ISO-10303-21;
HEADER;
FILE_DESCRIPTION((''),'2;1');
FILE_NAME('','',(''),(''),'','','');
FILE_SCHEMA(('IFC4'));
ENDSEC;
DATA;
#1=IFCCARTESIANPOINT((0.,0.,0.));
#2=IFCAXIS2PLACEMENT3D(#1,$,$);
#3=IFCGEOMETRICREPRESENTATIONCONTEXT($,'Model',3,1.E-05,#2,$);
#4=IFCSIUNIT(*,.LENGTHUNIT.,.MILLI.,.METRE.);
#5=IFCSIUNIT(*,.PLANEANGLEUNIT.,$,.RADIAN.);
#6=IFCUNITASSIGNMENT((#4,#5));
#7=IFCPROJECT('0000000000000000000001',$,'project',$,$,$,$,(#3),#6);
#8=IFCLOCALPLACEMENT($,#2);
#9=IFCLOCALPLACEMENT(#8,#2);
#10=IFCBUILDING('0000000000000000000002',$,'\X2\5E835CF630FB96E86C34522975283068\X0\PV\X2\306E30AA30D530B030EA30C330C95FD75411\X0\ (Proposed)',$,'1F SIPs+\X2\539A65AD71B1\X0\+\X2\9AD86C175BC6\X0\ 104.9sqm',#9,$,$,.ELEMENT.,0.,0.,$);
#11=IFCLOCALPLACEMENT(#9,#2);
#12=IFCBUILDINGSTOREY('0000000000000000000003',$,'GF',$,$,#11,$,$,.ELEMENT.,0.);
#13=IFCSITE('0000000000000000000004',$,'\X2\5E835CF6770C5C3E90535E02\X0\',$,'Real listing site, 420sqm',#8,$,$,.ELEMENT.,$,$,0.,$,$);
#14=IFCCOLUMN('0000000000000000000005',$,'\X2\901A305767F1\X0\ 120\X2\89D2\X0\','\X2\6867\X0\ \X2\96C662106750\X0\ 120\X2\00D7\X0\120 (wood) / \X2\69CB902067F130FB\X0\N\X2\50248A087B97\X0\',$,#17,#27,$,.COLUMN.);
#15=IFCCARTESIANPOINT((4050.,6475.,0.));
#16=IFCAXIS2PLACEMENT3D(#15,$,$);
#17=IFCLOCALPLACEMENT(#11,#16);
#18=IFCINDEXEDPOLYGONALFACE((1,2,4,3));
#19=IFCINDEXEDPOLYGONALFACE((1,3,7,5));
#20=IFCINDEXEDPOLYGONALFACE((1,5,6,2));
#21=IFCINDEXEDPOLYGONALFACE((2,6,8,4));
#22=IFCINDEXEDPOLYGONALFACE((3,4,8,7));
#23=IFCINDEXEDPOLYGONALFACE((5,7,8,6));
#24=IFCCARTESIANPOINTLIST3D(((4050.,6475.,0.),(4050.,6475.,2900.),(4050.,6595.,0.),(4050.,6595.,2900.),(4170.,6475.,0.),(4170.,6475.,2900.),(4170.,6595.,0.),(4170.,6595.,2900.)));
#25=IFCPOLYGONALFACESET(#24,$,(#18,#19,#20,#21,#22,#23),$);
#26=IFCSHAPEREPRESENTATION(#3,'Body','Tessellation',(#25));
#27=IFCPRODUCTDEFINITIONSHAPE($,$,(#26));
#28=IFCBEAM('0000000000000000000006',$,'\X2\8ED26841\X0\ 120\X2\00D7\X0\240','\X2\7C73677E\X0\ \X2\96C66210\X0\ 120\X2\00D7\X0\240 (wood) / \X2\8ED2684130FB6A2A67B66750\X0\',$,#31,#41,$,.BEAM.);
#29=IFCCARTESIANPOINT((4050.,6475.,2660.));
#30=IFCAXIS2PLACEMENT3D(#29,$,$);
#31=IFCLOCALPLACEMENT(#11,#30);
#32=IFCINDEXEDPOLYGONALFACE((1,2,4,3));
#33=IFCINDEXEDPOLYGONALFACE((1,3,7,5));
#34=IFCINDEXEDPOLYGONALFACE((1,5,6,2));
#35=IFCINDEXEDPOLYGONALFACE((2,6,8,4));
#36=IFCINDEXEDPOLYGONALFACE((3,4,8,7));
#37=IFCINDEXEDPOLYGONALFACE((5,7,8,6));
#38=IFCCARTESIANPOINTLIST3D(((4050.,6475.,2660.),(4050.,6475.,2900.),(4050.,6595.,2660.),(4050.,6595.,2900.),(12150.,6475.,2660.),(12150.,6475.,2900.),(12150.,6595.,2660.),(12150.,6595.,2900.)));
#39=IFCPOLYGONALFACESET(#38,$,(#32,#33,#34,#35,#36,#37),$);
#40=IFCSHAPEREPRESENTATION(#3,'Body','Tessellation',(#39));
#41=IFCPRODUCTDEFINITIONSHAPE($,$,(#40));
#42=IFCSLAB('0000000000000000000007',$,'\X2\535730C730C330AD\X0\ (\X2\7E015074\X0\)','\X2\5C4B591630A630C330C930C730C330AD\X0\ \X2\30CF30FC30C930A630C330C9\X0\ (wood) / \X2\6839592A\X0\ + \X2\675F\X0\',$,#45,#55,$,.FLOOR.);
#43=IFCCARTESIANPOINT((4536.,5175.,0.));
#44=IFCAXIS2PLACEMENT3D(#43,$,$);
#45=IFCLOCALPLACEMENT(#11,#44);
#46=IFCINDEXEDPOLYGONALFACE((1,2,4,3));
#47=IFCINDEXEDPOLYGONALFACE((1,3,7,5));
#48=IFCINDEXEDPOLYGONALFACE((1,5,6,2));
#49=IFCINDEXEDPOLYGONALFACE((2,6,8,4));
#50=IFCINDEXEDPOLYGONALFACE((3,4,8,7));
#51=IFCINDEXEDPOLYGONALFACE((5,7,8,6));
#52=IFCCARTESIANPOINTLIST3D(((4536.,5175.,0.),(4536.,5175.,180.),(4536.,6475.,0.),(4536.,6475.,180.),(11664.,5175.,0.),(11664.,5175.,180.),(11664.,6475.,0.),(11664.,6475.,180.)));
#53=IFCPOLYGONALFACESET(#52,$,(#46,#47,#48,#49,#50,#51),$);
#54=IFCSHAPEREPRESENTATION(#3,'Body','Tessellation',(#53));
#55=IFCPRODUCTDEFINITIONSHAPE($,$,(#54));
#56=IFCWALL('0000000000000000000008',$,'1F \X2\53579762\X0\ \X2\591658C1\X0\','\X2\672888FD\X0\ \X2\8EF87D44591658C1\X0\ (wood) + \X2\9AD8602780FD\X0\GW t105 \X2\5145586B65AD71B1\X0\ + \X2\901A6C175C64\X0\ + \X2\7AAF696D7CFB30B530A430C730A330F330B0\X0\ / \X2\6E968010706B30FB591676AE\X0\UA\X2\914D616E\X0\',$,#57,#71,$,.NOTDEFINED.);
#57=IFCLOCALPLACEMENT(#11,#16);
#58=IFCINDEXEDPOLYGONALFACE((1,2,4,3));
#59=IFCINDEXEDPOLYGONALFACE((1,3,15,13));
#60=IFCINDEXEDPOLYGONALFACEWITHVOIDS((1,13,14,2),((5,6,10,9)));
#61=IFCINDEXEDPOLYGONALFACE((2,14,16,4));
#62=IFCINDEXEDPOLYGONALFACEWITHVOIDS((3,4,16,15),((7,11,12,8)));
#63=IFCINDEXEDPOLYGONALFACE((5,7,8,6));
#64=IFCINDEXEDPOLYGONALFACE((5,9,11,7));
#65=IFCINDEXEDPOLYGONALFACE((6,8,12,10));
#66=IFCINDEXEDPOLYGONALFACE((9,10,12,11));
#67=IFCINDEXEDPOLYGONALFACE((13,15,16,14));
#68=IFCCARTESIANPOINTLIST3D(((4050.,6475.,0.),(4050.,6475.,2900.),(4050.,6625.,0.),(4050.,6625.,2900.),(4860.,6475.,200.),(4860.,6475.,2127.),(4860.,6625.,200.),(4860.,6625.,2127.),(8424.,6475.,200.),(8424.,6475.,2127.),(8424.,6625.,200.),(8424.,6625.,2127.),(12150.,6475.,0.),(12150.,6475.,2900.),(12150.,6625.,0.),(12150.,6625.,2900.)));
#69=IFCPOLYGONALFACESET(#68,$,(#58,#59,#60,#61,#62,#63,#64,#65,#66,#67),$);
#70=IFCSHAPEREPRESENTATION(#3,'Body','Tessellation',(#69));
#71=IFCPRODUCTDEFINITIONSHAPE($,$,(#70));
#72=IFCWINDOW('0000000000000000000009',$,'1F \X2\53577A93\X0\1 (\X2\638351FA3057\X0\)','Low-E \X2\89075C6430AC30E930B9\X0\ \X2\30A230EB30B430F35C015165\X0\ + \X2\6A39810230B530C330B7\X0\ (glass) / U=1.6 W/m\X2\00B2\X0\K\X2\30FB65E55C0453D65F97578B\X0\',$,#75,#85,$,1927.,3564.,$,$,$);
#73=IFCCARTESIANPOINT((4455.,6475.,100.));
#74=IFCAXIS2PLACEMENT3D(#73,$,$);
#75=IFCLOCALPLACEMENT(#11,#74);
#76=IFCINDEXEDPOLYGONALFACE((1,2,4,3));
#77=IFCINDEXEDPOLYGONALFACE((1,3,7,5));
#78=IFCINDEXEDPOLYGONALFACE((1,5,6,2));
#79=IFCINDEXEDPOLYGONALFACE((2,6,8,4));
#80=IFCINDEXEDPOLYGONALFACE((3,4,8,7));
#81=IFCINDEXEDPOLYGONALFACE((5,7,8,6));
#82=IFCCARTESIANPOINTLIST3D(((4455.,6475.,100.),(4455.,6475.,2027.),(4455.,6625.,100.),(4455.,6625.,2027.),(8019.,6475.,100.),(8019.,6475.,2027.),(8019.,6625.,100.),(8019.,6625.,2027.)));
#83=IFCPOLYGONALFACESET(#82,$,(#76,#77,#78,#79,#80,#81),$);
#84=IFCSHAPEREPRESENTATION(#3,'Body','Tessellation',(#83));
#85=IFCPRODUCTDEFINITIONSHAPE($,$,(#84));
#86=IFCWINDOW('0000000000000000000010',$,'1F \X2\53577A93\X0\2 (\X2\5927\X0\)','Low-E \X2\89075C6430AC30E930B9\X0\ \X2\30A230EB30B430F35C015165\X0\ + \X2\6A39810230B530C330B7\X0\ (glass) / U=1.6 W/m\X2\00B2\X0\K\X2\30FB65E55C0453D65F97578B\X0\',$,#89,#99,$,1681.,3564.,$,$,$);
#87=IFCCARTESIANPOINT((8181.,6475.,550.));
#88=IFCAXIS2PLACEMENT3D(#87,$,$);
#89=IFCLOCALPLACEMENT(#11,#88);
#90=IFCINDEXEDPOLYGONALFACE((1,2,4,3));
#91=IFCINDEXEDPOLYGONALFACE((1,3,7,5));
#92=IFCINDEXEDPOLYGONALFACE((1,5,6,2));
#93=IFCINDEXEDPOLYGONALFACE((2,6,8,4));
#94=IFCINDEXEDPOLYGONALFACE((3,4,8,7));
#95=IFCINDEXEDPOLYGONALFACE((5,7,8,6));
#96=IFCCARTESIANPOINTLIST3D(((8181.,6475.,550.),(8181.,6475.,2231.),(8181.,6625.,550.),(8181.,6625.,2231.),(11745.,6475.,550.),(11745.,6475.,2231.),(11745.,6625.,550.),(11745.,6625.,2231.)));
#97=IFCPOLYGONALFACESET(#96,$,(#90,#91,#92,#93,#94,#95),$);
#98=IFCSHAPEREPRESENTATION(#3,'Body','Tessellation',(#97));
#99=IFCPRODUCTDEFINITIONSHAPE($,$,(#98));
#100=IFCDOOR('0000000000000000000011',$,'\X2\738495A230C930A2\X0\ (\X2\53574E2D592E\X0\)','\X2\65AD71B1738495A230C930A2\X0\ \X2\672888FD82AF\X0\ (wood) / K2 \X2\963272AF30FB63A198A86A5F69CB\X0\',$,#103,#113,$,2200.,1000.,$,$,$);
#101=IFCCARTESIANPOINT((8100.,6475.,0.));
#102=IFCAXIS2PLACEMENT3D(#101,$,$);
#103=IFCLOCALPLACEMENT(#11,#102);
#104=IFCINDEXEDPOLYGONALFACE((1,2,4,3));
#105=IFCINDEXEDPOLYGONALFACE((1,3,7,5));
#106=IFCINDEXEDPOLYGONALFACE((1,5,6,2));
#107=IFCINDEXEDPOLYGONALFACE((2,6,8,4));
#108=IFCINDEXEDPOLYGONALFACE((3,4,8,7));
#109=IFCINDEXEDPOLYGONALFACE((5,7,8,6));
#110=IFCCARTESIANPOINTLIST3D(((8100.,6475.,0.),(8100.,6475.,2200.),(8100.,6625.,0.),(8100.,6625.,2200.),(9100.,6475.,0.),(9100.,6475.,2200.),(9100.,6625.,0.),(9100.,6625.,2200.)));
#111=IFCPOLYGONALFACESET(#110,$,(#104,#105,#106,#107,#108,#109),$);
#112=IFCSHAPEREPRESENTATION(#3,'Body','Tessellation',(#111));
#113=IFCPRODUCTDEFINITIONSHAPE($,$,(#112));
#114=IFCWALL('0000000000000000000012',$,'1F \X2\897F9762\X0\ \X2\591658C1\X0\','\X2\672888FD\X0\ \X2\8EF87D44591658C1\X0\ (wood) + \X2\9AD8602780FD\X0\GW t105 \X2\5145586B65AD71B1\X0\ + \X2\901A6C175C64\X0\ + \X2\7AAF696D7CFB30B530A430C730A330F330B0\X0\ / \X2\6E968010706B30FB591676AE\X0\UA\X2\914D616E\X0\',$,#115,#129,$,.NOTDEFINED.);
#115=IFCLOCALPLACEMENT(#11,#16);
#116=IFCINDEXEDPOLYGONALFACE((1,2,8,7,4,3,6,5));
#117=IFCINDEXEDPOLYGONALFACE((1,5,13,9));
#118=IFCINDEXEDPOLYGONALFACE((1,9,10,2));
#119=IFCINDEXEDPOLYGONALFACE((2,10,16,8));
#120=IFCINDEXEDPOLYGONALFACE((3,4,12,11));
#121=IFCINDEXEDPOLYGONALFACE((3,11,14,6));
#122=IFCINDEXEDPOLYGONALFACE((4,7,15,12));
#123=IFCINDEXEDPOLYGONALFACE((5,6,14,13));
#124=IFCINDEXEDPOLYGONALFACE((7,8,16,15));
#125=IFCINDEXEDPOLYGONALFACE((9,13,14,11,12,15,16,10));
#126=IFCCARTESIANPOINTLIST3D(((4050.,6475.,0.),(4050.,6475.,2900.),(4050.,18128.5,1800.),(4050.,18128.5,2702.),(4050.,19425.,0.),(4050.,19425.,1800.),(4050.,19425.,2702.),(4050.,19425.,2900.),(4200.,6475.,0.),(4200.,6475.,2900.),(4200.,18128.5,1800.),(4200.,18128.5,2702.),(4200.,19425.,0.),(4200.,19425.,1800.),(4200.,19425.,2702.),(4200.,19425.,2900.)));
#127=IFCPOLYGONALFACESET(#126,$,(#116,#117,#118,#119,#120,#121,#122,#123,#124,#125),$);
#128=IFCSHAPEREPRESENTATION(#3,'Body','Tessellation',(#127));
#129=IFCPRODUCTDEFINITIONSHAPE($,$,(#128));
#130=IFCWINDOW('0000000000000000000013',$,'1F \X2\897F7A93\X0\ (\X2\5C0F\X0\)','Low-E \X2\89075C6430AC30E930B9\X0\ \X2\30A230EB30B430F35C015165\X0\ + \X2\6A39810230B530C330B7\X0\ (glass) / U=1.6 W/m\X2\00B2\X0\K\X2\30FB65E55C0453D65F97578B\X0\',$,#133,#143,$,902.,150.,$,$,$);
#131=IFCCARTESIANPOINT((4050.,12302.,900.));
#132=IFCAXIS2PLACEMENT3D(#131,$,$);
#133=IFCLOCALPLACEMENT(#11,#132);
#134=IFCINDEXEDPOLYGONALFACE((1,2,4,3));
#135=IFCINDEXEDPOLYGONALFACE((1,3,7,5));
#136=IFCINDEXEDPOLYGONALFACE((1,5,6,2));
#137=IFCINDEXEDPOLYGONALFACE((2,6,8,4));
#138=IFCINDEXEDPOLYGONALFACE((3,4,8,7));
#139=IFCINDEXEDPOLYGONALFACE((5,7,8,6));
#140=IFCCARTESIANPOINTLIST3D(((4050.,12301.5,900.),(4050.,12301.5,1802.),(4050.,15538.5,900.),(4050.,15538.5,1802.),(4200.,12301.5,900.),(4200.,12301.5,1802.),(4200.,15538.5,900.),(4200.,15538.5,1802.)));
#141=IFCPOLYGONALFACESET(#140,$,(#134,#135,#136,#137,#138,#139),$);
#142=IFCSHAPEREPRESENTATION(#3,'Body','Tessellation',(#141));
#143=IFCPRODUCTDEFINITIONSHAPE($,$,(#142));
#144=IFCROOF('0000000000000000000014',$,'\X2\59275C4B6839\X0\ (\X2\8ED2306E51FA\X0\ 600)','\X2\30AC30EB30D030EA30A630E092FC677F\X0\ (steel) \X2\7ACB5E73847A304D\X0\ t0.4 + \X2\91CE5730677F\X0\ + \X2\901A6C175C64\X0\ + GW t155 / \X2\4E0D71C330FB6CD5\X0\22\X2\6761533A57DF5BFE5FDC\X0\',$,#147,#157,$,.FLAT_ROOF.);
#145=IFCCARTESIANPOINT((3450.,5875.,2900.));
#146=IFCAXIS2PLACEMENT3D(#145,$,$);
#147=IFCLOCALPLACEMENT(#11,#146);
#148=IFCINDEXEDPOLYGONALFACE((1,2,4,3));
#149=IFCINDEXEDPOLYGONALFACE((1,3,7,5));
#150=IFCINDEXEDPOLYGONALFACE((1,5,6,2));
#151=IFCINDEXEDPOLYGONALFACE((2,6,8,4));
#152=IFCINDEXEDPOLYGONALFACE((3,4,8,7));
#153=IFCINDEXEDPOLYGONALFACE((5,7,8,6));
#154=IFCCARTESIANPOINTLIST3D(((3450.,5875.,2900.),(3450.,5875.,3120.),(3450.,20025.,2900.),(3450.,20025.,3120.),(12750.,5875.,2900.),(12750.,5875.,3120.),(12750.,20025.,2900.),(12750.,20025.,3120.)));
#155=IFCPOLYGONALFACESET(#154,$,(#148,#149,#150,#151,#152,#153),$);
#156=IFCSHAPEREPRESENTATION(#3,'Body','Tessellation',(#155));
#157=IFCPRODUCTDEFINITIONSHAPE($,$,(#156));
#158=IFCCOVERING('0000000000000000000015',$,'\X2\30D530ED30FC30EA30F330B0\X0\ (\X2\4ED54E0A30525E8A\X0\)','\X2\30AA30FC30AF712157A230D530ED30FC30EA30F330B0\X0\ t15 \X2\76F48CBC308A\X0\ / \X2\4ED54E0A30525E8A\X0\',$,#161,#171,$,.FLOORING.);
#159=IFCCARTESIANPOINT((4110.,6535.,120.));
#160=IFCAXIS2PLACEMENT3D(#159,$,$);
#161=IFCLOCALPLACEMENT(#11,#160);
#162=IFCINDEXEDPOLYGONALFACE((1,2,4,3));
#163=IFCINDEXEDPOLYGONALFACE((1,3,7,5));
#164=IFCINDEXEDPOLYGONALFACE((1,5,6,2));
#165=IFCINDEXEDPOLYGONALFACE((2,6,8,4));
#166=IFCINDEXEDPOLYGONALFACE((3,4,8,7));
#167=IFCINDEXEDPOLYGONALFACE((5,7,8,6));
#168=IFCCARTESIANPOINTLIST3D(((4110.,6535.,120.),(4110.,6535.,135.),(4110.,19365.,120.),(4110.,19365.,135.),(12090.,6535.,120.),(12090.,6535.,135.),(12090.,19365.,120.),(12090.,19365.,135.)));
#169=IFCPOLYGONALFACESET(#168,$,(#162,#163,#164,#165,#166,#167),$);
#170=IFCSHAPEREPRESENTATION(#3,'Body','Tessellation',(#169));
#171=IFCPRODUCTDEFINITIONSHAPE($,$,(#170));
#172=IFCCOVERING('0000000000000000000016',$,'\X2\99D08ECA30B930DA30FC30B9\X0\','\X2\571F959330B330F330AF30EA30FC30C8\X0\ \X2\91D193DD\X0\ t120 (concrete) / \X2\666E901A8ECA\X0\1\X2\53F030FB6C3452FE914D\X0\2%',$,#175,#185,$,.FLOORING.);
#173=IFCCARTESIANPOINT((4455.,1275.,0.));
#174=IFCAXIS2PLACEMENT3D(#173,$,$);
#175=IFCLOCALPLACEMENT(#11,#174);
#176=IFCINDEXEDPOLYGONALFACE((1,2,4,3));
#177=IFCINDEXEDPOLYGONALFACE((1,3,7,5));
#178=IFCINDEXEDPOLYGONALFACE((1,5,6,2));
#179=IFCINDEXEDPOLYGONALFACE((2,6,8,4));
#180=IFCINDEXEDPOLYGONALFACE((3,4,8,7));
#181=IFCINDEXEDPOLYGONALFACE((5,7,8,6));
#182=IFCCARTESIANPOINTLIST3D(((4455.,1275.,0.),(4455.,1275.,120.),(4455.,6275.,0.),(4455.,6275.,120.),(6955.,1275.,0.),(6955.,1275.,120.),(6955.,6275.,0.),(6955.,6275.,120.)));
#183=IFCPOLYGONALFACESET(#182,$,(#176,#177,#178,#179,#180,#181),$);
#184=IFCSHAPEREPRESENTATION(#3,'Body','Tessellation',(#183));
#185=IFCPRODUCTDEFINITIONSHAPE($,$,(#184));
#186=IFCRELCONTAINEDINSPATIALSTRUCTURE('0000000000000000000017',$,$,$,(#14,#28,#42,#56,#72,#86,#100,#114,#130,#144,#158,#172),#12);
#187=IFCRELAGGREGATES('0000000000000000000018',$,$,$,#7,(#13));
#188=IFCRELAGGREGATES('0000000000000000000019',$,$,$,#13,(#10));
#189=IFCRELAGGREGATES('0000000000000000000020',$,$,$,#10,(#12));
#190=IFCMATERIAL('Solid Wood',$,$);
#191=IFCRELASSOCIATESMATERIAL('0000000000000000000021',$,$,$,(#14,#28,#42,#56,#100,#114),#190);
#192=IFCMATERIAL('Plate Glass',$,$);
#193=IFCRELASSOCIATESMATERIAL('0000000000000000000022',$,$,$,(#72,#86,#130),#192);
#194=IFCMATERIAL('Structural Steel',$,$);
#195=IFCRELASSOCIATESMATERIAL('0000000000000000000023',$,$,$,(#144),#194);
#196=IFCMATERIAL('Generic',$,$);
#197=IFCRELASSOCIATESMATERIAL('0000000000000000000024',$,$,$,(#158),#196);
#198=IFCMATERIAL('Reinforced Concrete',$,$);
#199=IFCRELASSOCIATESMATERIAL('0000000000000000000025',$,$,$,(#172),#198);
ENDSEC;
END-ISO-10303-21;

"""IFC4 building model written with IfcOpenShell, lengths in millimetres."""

from ifc_helpers import new_model, si_unit, frame, frame_2d, origin, place, context, project, spatial, rectangle, extrude, material, element, fill, save


model = new_model("IFC4")

# Units and contexts
model_context = context("Model", 3, precision=1e-05, world=origin())
ifc_project = project(units=[si_unit("LENGTHUNIT", "METRE", prefix="MILLI"), si_unit("PLANEANGLEUNIT", "RADIAN")], contexts=[model_context])

# Site, building, storey
site_placement = place(None, origin())
site = spatial("IfcSite", under=ifc_project, at=site_placement, Name="広島県尾道市", ObjectType="Real listing site, 420sqm", CompositionType="ELEMENT", RefElevation=0.0)
building_placement = place(site_placement, origin())
building = spatial("IfcBuilding", under=site, at=building_placement, Name="広島・雨水利用とPVのオフグリッド志向 (Proposed)", ObjectType="1F SIPs+厚断熱+高気密 104.9sqm", CompositionType="ELEMENT", ElevationOfRefHeight=0.0, ElevationOfTerrain=0.0)
storey_placement = place(building_placement, origin())
storey = spatial("IfcBuildingStorey", under=building, at=storey_placement, Name="GF", CompositionType="ELEMENT", Elevation=0.0)

# Column
ifc_material_1 = material(Name="Solid Wood")
column_1_placement = place(storey_placement, frame((4050.0, 6475.0, 0.0)))
element("IfcColumn", 1, at=column_1_placement, inside=storey, material=ifc_material_1, Name="通し柱 120角", Description="桧 集成材 120×120 (wood) / 構造柱・N値計算", PredefinedType="COLUMN", context=model_context, shape_type="SweptSolid", body=[
    extrude(rectangle(XDim=120.0, YDim=120.0, at=frame_2d((60.0, 60.0))), frame((4050.0, 6475.0, 0.0)), (0.0, 0.0, 1.0), 2900.0),
])

# Beam
beam_1_placement = place(storey_placement, frame((4050.0, 6475.0, 2660.0)))
element("IfcBeam", 2, at=beam_1_placement, inside=storey, material=ifc_material_1, Name="軒桁 120×240", Description="米松 集成 120×240 (wood) / 軒桁・横架材", PredefinedType="BEAM", context=model_context, shape_type="SweptSolid", body=[
    extrude(rectangle(XDim=8100.0, YDim=120.0, at=frame_2d((4050.0, 60.0))), frame((4050.0, 6475.0, 2660.0)), (0.0, 0.0, 1.0), 240.0),
])

# Slab
ifc_material_2 = material(Name="Reinforced Concrete")
slab_1_placement = place(storey_placement, frame((4536.0, 5175.0, 0.0)))
element("IfcSlab", 3, at=slab_1_placement, inside=storey, material=ifc_material_1, Name="南デッキ (縁側)", Description="屋外ウッドデッキ ハードウッド (wood) / 根太 + 束", PredefinedType="FLOOR", context=model_context, shape_type="SweptSolid", body=[
    extrude(rectangle(XDim=7128.0, YDim=1300.0, at=frame_2d((3564.0, 650.0))), frame((4536.0, 5175.0, 0.0)), (0.0, 0.0, 1.0), 180.0),
])

# Wall, openings, windows, door
wall_1_placement = place(storey_placement, frame((4050.0, 6475.0, 0.0)))
wall_1 = element("IfcWall", 4, at=wall_1_placement, inside=storey, material=ifc_material_1, Name="1F 南面 外壁", Description="木製 軸組外壁 (wood) + 高性能GW t105 充填断熱 + 通気層 + 窯業系サイディング / 準耐火・外皮UA配慮", PredefinedType="NOTDEFINED", context=model_context, shape_type="SweptSolid", body=[
    extrude(rectangle(XDim=8100.0, YDim=150.0, at=frame_2d((4050.0, 75.0))), frame((4050.0, 6475.0, 0.0)), (0.0, 0.0, 1.0), 2900.0),
])
opening_1_placement = place(storey_placement, frame((4455.0, 6475.0, 100.0)))
opening_1 = element("IfcOpeningElement", 5, at=opening_1_placement, cuts=wall_1, PredefinedType="NOTDEFINED", context=model_context, shape_type="SweptSolid", body=[
    extrude(rectangle(XDim=3564.0, YDim=150.0, at=frame_2d((1782.0, 75.0))), frame((4455.0, 6475.0, 100.0)), (0.0, 0.0, 1.0), 1927.0),
])
opening_2_placement = place(storey_placement, frame((8181.0, 6475.0, 550.0)))
opening_2 = element("IfcOpeningElement", 6, at=opening_2_placement, cuts=wall_1, PredefinedType="NOTDEFINED", context=model_context, shape_type="SweptSolid", body=[
    extrude(rectangle(XDim=3564.0, YDim=150.0, at=frame_2d((1782.0, 75.0))), frame((8181.0, 6475.0, 550.0)), (0.0, 0.0, 1.0), 1681.0),
])
opening_3_placement = place(storey_placement, frame((8100.0, 6475.0, 0.0)))
opening_3 = element("IfcOpeningElement", 7, at=opening_3_placement, cuts=wall_1, PredefinedType="NOTDEFINED", context=model_context, shape_type="SweptSolid", body=[
    extrude(rectangle(XDim=1000.0, YDim=150.0, at=frame_2d((500.0, 75.0))), frame((8100.0, 6475.0, 0.0)), (0.0, 0.0, 1.0), 2200.0),
])
ifc_material_3 = material(Name="Plate Glass")
window_1_placement = place(storey_placement, frame((4455.0, 6475.0, 100.0)))
window_1 = element("IfcWindow", 8, at=window_1_placement, inside=storey, material=ifc_material_3, Name="1F 南窓1 (掃出し)", Description="Low-E 複層ガラス アルゴン封入 + 樹脂サッシ (glass) / U=1.6 W/m²K・日射取得型", OverallHeight=1927.0, OverallWidth=3564.0, context=model_context, shape_type="SweptSolid", body=[
    extrude(rectangle(XDim=3564.0, YDim=150.0, at=frame_2d((1782.0, 75.0))), frame((4455.0, 6475.0, 100.0)), (0.0, 0.0, 1.0), 1927.0),
])
fill(opening_1, window_1)
window_2_placement = place(storey_placement, frame((8181.0, 6475.0, 550.0)))
window_2 = element("IfcWindow", 9, at=window_2_placement, inside=storey, material=ifc_material_3, Name="1F 南窓2 (大)", Description="Low-E 複層ガラス アルゴン封入 + 樹脂サッシ (glass) / U=1.6 W/m²K・日射取得型", OverallHeight=1681.0, OverallWidth=3564.0, context=model_context, shape_type="SweptSolid", body=[
    extrude(rectangle(XDim=3564.0, YDim=150.0, at=frame_2d((1782.0, 75.0))), frame((8181.0, 6475.0, 550.0)), (0.0, 0.0, 1.0), 1681.0),
])
fill(opening_2, window_2)
door_placement = place(storey_placement, frame((8100.0, 6475.0, 0.0)))
door = element("IfcDoor", 10, at=door_placement, inside=storey, material=ifc_material_1, Name="玄関ドア (南中央)", Description="断熱玄関ドア 木製芯 (wood) / K2 防犯・採風機構", OverallHeight=2200.0, OverallWidth=1000.0, context=model_context, shape_type="SweptSolid", body=[
    extrude(rectangle(XDim=1000.0, YDim=150.0, at=frame_2d((500.0, 75.0))), frame((8100.0, 6475.0, 0.0)), (0.0, 0.0, 1.0), 2200.0),
])
fill(opening_3, door)

# Wall, opening, window
wall_2_placement = place(storey_placement, frame((4050.0, 6475.0, 0.0)))
wall_2 = element("IfcWall", 11, at=wall_2_placement, inside=storey, material=ifc_material_1, Name="1F 西面 外壁", Description="木製 軸組外壁 (wood) + 高性能GW t105 充填断熱 + 通気層 + 窯業系サイディング / 準耐火・外皮UA配慮", PredefinedType="NOTDEFINED", context=model_context, shape_type="SweptSolid", body=[
    extrude(rectangle(XDim=150.0, YDim=12950.0, at=frame_2d((75.0, 6475.0))), frame((4050.0, 6475.0, 0.0)), (0.0, 0.0, 1.0), 2900.0),
])
opening_4_placement = place(storey_placement, frame((4050.0, 12302.0, 900.0)))
opening_4 = element("IfcOpeningElement", 12, at=opening_4_placement, cuts=wall_2, PredefinedType="NOTDEFINED", context=model_context, shape_type="SweptSolid", body=[
    extrude(rectangle(XDim=150.0, YDim=3237.0, at=frame_2d((75.0, 1618.0))), frame((4050.0, 12302.0, 900.0)), (0.0, 0.0, 1.0), 902.0),
])
window_3_placement = place(storey_placement, frame((4050.0, 12302.0, 900.0)))
window_3 = element("IfcWindow", 13, at=window_3_placement, inside=storey, material=ifc_material_3, Name="1F 西窓 (小)", Description="Low-E 複層ガラス アルゴン封入 + 樹脂サッシ (glass) / U=1.6 W/m²K・日射取得型", OverallHeight=902.0, OverallWidth=150.0, context=model_context, shape_type="SweptSolid", body=[
    extrude(rectangle(XDim=150.0, YDim=3237.0, at=frame_2d((75.0, 1618.0))), frame((4050.0, 12302.0, 900.0)), (0.0, 0.0, 1.0), 902.0),
])
fill(opening_4, window_3)

# Roof
ifc_material_4 = material(Name="Structural Steel")
roof_placement = place(storey_placement, frame((3450.0, 5875.0, 2900.0)))
element("IfcRoof", 14, at=roof_placement, inside=storey, material=ifc_material_4, Name="大屋根 (軒の出 600)", Description="ガルバリウム鋼板 (steel) 立平葺き t0.4 + 野地板 + 通気層 + GW t155 / 不燃・法22条区域対応", PredefinedType="FLAT_ROOF", context=model_context, shape_type="SweptSolid", body=[
    extrude(rectangle(XDim=9300.0, YDim=14150.0, at=frame_2d((4650.0, 7075.0))), frame((3450.0, 5875.0, 2900.0)), (0.0, 0.0, 1.0), 220.0),
])

# Coverings
ifc_material_5 = material(Name="Generic")
covering_1_placement = place(storey_placement, frame((4110.0, 6535.0, 120.0)))
element("IfcCovering", 15, at=covering_1_placement, inside=storey, material=ifc_material_5, Name="フローリング (仕上げ床)", Description="オーク無垢フローリング t15 直貼り / 仕上げ床", PredefinedType="FLOORING", context=model_context, shape_type="SweptSolid", body=[
    extrude(rectangle(XDim=7980.0, YDim=12830.0, at=frame_2d((3990.0, 6415.0))), frame((4110.0, 6535.0, 120.0)), (0.0, 0.0, 1.0), 15.0),
])
covering_2_placement = place(storey_placement, frame((4455.0, 1275.0, 0.0)))
element("IfcCovering", 16, at=covering_2_placement, inside=storey, material=ifc_material_2, Name="駐車スペース", Description="土間コンクリート 金鏝 t120 (concrete) / 普通車1台・水勾配2%", PredefinedType="FLOORING", context=model_context, shape_type="SweptSolid", body=[
    extrude(rectangle(XDim=2500.0, YDim=5000.0, at=frame_2d((1250.0, 2500.0))), frame((4455.0, 1275.0, 0.0)), (0.0, 0.0, 1.0), 120.0),
])

save(model, "model.ifc")
